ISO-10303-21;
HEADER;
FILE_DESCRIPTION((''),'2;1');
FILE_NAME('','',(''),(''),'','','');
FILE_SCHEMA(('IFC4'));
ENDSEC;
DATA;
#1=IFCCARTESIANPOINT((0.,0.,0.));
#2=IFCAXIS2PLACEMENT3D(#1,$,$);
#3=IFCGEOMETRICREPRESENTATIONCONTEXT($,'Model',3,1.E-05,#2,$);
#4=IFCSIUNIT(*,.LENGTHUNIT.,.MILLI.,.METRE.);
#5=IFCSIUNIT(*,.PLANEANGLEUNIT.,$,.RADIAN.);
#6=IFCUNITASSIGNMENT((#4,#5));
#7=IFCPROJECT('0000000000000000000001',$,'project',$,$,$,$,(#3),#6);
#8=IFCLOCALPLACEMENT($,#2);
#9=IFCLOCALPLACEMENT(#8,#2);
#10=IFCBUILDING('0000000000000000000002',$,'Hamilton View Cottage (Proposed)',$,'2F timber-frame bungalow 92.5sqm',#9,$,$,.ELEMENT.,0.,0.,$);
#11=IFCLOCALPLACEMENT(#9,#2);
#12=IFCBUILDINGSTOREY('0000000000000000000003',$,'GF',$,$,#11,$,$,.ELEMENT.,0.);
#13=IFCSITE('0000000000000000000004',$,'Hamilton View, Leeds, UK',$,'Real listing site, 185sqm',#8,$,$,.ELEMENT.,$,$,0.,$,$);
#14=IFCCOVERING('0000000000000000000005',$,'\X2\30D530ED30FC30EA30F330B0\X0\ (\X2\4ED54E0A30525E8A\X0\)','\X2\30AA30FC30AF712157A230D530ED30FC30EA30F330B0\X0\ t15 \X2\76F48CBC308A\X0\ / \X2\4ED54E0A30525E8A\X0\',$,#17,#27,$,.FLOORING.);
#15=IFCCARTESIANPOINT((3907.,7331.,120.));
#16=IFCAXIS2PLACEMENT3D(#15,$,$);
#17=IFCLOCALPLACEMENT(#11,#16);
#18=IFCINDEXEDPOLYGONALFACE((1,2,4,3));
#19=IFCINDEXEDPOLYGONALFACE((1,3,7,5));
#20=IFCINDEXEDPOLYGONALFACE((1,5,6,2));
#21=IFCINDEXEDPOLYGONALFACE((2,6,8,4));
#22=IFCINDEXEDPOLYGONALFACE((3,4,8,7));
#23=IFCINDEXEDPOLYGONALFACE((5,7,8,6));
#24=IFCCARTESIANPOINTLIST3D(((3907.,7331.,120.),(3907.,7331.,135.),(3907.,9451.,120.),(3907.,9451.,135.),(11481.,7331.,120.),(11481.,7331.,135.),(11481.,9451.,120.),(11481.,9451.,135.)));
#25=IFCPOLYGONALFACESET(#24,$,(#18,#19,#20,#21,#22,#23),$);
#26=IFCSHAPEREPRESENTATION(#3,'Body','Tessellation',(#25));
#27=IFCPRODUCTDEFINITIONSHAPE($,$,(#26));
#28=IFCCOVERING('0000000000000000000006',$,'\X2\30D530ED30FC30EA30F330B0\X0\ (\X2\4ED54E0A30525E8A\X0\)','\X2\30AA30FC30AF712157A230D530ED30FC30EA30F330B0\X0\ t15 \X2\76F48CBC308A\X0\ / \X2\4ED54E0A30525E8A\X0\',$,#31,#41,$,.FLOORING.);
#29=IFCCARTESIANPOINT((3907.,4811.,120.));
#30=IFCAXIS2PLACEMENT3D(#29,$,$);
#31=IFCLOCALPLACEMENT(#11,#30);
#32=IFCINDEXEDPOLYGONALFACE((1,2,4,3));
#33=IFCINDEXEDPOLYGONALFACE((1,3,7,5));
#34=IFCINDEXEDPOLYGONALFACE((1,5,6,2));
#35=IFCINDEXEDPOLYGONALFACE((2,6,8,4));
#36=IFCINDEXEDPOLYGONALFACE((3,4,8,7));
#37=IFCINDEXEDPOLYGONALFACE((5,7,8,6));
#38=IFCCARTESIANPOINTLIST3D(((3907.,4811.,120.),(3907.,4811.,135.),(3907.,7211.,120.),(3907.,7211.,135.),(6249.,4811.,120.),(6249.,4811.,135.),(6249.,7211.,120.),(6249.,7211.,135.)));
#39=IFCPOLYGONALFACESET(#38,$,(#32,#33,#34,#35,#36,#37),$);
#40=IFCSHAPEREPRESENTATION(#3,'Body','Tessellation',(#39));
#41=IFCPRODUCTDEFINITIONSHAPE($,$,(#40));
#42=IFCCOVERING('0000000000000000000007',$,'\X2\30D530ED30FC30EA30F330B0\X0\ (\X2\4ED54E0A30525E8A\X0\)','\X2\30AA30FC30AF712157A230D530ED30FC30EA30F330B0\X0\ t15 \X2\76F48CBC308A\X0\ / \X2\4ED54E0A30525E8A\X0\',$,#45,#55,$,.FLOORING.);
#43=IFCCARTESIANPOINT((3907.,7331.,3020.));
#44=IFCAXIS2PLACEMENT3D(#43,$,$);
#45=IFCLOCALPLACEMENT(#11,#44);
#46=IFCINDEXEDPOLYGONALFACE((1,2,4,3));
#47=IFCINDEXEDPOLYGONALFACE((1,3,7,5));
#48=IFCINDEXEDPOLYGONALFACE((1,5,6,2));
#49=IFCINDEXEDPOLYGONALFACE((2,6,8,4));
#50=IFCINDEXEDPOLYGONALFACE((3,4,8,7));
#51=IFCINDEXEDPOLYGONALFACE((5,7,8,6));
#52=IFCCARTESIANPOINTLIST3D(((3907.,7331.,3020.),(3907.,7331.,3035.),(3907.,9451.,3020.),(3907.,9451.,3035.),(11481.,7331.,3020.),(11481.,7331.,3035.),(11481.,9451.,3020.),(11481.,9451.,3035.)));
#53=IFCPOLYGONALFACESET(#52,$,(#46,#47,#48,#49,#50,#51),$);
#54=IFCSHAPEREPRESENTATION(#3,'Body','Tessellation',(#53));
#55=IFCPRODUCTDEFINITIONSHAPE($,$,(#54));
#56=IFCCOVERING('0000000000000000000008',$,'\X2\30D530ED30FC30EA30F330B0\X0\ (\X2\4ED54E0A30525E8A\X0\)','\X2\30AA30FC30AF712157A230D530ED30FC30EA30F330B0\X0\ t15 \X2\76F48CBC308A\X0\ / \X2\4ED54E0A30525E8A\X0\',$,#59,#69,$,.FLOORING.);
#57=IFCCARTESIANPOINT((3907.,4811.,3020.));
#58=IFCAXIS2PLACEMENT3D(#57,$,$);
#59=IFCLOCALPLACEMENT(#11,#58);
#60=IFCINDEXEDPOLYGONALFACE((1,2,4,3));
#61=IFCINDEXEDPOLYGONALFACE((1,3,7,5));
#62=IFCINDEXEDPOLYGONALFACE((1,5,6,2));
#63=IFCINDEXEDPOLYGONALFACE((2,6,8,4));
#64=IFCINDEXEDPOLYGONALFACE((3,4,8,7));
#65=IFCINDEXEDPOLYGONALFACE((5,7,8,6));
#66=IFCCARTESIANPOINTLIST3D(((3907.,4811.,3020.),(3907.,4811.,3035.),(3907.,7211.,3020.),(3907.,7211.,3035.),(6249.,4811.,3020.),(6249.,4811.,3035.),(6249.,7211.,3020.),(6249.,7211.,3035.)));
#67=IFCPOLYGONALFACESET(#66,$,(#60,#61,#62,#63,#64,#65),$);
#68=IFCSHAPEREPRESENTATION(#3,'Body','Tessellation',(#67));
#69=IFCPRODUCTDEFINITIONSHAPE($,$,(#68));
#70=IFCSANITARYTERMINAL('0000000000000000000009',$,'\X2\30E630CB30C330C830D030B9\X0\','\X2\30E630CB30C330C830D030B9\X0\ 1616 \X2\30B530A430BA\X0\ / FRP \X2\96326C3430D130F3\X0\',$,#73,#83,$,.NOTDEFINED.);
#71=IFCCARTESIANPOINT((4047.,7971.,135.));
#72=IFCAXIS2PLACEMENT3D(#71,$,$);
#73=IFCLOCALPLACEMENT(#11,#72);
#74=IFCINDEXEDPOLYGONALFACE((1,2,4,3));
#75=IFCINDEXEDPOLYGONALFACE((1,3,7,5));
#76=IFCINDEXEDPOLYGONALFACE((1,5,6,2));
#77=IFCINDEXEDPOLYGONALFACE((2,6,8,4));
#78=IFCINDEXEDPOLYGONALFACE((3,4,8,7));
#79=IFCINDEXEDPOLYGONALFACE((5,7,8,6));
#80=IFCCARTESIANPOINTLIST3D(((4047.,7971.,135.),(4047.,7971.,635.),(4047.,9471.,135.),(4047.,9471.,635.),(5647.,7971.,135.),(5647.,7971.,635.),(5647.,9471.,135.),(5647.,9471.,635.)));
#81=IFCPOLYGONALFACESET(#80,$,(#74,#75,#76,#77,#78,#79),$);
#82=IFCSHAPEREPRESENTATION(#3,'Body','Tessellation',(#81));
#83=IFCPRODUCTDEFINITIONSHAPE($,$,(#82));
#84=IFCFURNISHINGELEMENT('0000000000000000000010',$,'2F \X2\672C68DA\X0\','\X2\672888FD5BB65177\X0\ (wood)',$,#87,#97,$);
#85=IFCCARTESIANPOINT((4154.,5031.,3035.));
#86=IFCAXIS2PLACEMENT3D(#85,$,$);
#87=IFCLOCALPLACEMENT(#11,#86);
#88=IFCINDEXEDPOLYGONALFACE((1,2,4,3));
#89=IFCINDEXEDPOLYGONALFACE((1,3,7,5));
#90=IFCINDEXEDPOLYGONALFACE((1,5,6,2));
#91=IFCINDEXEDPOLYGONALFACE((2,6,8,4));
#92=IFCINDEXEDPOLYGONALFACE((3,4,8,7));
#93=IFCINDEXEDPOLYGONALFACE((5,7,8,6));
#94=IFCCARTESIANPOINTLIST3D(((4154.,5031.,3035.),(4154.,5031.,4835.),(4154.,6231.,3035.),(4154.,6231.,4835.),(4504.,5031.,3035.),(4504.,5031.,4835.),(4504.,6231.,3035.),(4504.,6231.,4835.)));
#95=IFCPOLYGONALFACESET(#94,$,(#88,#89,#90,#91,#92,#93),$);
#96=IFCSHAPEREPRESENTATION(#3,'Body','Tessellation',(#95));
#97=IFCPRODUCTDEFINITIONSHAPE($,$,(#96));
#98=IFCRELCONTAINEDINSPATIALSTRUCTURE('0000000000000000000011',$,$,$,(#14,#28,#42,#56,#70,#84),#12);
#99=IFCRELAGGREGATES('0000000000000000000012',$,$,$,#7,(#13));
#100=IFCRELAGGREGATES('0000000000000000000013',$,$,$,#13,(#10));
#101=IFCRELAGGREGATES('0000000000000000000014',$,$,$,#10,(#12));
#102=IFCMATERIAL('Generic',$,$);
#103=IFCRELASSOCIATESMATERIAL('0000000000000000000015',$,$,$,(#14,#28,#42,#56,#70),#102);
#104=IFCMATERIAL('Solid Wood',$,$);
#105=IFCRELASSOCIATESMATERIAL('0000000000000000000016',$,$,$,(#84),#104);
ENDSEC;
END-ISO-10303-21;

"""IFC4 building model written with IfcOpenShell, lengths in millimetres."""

from ifc_helpers import new_model, si_unit, frame, frame_2d, origin, place, context, project, spatial, rectangle, extrude, material, element, save


model = new_model("IFC4")

# Units and contexts
model_context = context("Model", 3, precision=1e-05, world=origin())
ifc_project = project(units=[si_unit("LENGTHUNIT", "METRE", prefix="MILLI"), si_unit("PLANEANGLEUNIT", "RADIAN")], contexts=[model_context])

# Site, building, storey
site_placement = place(None, origin())
site = spatial("IfcSite", under=ifc_project, at=site_placement, Name="Hamilton View, Leeds, UK", ObjectType="Real listing site, 185sqm", CompositionType="ELEMENT", RefElevation=0.0)
building_placement = place(site_placement, origin())
building = spatial("IfcBuilding", under=site, at=building_placement, Name="Hamilton View Cottage (Proposed)", ObjectType="2F timber-frame bungalow 92.5sqm", CompositionType="ELEMENT", ElevationOfRefHeight=0.0, ElevationOfTerrain=0.0)
storey_placement = place(building_placement, origin())
storey = spatial("IfcBuildingStorey", under=building, at=storey_placement, Name="GF", CompositionType="ELEMENT", Elevation=0.0)

# Shared definitions
ifc_material_1 = material(Name="Solid Wood")

# Coverings
ifc_material_2 = material(Name="Generic")
covering_1_placement = place(storey_placement, frame((3907.0, 7331.0, 120.0)))
element("IfcCovering", 1, at=covering_1_placement, inside=storey, material=ifc_material_2, Name="フローリング (仕上げ床)", Description="オーク無垢フローリング t15 直貼り / 仕上げ床", PredefinedType="FLOORING", context=model_context, shape_type="SweptSolid", body=[
    extrude(rectangle(XDim=7574.0, YDim=2120.0, at=frame_2d((3787.0, 1060.0))), frame((3907.0, 7331.0, 120.0)), (0.0, 0.0, 1.0), 15.0),
])
covering_2_placement = place(storey_placement, frame((3907.0, 4811.0, 120.0)))
element("IfcCovering", 2, at=covering_2_placement, inside=storey, material=ifc_material_2, Name="フローリング (仕上げ床)", Description="オーク無垢フローリング t15 直貼り / 仕上げ床", PredefinedType="FLOORING", context=model_context, shape_type="SweptSolid", body=[
    extrude(rectangle(XDim=2342.0, YDim=2400.0, at=frame_2d((1171.0, 1200.0))), frame((3907.0, 4811.0, 120.0)), (0.0, 0.0, 1.0), 15.0),
])
covering_3_placement = place(storey_placement, frame((3907.0, 7331.0, 3020.0)))
element("IfcCovering", 3, at=covering_3_placement, inside=storey, material=ifc_material_2, Name="フローリング (仕上げ床)", Description="オーク無垢フローリング t15 直貼り / 仕上げ床", PredefinedType="FLOORING", context=model_context, shape_type="SweptSolid", body=[
    extrude(rectangle(XDim=7574.0, YDim=2120.0, at=frame_2d((3787.0, 1060.0))), frame((3907.0, 7331.0, 3020.0)), (0.0, 0.0, 1.0), 15.0),
])
covering_4_placement = place(storey_placement, frame((3907.0, 4811.0, 3020.0)))
element("IfcCovering", 4, at=covering_4_placement, inside=storey, material=ifc_material_2, Name="フローリング (仕上げ床)", Description="オーク無垢フローリング t15 直貼り / 仕上げ床", PredefinedType="FLOORING", context=model_context, shape_type="SweptSolid", body=[
    extrude(rectangle(XDim=2342.0, YDim=2400.0, at=frame_2d((1171.0, 1200.0))), frame((3907.0, 4811.0, 3020.0)), (0.0, 0.0, 1.0), 15.0),
])

# Sanitary terminal
sanitary_terminal_placement = place(storey_placement, frame((4047.0, 7971.0, 135.0)))
element("IfcSanitaryTerminal", 5, at=sanitary_terminal_placement, inside=storey, material=ifc_material_2, Name="ユニットバス", Description="ユニットバス 1616 サイズ / FRP 防水パン", PredefinedType="NOTDEFINED", context=model_context, shape_type="SweptSolid", body=[
    extrude(rectangle(XDim=1600.0, YDim=1500.0, at=frame_2d((800.0, 750.0))), frame((4047.0, 7971.0, 135.0)), (0.0, 0.0, 1.0), 500.0),
])

# Furnishing element
furnishing_placement = place(storey_placement, frame((4154.0, 5031.0, 3035.0)))
element("IfcFurnishingElement", 6, at=furnishing_placement, inside=storey, material=ifc_material_1, Name="2F 本棚", Description="木製家具 (wood)", context=model_context, shape_type="SweptSolid", body=[
    extrude(rectangle(XDim=350.0, YDim=1200.0, at=frame_2d((175.0, 600.0))), frame((4154.0, 5031.0, 3035.0)), (0.0, 0.0, 1.0), 1800.0),
])

save(model, "model.ifc")
